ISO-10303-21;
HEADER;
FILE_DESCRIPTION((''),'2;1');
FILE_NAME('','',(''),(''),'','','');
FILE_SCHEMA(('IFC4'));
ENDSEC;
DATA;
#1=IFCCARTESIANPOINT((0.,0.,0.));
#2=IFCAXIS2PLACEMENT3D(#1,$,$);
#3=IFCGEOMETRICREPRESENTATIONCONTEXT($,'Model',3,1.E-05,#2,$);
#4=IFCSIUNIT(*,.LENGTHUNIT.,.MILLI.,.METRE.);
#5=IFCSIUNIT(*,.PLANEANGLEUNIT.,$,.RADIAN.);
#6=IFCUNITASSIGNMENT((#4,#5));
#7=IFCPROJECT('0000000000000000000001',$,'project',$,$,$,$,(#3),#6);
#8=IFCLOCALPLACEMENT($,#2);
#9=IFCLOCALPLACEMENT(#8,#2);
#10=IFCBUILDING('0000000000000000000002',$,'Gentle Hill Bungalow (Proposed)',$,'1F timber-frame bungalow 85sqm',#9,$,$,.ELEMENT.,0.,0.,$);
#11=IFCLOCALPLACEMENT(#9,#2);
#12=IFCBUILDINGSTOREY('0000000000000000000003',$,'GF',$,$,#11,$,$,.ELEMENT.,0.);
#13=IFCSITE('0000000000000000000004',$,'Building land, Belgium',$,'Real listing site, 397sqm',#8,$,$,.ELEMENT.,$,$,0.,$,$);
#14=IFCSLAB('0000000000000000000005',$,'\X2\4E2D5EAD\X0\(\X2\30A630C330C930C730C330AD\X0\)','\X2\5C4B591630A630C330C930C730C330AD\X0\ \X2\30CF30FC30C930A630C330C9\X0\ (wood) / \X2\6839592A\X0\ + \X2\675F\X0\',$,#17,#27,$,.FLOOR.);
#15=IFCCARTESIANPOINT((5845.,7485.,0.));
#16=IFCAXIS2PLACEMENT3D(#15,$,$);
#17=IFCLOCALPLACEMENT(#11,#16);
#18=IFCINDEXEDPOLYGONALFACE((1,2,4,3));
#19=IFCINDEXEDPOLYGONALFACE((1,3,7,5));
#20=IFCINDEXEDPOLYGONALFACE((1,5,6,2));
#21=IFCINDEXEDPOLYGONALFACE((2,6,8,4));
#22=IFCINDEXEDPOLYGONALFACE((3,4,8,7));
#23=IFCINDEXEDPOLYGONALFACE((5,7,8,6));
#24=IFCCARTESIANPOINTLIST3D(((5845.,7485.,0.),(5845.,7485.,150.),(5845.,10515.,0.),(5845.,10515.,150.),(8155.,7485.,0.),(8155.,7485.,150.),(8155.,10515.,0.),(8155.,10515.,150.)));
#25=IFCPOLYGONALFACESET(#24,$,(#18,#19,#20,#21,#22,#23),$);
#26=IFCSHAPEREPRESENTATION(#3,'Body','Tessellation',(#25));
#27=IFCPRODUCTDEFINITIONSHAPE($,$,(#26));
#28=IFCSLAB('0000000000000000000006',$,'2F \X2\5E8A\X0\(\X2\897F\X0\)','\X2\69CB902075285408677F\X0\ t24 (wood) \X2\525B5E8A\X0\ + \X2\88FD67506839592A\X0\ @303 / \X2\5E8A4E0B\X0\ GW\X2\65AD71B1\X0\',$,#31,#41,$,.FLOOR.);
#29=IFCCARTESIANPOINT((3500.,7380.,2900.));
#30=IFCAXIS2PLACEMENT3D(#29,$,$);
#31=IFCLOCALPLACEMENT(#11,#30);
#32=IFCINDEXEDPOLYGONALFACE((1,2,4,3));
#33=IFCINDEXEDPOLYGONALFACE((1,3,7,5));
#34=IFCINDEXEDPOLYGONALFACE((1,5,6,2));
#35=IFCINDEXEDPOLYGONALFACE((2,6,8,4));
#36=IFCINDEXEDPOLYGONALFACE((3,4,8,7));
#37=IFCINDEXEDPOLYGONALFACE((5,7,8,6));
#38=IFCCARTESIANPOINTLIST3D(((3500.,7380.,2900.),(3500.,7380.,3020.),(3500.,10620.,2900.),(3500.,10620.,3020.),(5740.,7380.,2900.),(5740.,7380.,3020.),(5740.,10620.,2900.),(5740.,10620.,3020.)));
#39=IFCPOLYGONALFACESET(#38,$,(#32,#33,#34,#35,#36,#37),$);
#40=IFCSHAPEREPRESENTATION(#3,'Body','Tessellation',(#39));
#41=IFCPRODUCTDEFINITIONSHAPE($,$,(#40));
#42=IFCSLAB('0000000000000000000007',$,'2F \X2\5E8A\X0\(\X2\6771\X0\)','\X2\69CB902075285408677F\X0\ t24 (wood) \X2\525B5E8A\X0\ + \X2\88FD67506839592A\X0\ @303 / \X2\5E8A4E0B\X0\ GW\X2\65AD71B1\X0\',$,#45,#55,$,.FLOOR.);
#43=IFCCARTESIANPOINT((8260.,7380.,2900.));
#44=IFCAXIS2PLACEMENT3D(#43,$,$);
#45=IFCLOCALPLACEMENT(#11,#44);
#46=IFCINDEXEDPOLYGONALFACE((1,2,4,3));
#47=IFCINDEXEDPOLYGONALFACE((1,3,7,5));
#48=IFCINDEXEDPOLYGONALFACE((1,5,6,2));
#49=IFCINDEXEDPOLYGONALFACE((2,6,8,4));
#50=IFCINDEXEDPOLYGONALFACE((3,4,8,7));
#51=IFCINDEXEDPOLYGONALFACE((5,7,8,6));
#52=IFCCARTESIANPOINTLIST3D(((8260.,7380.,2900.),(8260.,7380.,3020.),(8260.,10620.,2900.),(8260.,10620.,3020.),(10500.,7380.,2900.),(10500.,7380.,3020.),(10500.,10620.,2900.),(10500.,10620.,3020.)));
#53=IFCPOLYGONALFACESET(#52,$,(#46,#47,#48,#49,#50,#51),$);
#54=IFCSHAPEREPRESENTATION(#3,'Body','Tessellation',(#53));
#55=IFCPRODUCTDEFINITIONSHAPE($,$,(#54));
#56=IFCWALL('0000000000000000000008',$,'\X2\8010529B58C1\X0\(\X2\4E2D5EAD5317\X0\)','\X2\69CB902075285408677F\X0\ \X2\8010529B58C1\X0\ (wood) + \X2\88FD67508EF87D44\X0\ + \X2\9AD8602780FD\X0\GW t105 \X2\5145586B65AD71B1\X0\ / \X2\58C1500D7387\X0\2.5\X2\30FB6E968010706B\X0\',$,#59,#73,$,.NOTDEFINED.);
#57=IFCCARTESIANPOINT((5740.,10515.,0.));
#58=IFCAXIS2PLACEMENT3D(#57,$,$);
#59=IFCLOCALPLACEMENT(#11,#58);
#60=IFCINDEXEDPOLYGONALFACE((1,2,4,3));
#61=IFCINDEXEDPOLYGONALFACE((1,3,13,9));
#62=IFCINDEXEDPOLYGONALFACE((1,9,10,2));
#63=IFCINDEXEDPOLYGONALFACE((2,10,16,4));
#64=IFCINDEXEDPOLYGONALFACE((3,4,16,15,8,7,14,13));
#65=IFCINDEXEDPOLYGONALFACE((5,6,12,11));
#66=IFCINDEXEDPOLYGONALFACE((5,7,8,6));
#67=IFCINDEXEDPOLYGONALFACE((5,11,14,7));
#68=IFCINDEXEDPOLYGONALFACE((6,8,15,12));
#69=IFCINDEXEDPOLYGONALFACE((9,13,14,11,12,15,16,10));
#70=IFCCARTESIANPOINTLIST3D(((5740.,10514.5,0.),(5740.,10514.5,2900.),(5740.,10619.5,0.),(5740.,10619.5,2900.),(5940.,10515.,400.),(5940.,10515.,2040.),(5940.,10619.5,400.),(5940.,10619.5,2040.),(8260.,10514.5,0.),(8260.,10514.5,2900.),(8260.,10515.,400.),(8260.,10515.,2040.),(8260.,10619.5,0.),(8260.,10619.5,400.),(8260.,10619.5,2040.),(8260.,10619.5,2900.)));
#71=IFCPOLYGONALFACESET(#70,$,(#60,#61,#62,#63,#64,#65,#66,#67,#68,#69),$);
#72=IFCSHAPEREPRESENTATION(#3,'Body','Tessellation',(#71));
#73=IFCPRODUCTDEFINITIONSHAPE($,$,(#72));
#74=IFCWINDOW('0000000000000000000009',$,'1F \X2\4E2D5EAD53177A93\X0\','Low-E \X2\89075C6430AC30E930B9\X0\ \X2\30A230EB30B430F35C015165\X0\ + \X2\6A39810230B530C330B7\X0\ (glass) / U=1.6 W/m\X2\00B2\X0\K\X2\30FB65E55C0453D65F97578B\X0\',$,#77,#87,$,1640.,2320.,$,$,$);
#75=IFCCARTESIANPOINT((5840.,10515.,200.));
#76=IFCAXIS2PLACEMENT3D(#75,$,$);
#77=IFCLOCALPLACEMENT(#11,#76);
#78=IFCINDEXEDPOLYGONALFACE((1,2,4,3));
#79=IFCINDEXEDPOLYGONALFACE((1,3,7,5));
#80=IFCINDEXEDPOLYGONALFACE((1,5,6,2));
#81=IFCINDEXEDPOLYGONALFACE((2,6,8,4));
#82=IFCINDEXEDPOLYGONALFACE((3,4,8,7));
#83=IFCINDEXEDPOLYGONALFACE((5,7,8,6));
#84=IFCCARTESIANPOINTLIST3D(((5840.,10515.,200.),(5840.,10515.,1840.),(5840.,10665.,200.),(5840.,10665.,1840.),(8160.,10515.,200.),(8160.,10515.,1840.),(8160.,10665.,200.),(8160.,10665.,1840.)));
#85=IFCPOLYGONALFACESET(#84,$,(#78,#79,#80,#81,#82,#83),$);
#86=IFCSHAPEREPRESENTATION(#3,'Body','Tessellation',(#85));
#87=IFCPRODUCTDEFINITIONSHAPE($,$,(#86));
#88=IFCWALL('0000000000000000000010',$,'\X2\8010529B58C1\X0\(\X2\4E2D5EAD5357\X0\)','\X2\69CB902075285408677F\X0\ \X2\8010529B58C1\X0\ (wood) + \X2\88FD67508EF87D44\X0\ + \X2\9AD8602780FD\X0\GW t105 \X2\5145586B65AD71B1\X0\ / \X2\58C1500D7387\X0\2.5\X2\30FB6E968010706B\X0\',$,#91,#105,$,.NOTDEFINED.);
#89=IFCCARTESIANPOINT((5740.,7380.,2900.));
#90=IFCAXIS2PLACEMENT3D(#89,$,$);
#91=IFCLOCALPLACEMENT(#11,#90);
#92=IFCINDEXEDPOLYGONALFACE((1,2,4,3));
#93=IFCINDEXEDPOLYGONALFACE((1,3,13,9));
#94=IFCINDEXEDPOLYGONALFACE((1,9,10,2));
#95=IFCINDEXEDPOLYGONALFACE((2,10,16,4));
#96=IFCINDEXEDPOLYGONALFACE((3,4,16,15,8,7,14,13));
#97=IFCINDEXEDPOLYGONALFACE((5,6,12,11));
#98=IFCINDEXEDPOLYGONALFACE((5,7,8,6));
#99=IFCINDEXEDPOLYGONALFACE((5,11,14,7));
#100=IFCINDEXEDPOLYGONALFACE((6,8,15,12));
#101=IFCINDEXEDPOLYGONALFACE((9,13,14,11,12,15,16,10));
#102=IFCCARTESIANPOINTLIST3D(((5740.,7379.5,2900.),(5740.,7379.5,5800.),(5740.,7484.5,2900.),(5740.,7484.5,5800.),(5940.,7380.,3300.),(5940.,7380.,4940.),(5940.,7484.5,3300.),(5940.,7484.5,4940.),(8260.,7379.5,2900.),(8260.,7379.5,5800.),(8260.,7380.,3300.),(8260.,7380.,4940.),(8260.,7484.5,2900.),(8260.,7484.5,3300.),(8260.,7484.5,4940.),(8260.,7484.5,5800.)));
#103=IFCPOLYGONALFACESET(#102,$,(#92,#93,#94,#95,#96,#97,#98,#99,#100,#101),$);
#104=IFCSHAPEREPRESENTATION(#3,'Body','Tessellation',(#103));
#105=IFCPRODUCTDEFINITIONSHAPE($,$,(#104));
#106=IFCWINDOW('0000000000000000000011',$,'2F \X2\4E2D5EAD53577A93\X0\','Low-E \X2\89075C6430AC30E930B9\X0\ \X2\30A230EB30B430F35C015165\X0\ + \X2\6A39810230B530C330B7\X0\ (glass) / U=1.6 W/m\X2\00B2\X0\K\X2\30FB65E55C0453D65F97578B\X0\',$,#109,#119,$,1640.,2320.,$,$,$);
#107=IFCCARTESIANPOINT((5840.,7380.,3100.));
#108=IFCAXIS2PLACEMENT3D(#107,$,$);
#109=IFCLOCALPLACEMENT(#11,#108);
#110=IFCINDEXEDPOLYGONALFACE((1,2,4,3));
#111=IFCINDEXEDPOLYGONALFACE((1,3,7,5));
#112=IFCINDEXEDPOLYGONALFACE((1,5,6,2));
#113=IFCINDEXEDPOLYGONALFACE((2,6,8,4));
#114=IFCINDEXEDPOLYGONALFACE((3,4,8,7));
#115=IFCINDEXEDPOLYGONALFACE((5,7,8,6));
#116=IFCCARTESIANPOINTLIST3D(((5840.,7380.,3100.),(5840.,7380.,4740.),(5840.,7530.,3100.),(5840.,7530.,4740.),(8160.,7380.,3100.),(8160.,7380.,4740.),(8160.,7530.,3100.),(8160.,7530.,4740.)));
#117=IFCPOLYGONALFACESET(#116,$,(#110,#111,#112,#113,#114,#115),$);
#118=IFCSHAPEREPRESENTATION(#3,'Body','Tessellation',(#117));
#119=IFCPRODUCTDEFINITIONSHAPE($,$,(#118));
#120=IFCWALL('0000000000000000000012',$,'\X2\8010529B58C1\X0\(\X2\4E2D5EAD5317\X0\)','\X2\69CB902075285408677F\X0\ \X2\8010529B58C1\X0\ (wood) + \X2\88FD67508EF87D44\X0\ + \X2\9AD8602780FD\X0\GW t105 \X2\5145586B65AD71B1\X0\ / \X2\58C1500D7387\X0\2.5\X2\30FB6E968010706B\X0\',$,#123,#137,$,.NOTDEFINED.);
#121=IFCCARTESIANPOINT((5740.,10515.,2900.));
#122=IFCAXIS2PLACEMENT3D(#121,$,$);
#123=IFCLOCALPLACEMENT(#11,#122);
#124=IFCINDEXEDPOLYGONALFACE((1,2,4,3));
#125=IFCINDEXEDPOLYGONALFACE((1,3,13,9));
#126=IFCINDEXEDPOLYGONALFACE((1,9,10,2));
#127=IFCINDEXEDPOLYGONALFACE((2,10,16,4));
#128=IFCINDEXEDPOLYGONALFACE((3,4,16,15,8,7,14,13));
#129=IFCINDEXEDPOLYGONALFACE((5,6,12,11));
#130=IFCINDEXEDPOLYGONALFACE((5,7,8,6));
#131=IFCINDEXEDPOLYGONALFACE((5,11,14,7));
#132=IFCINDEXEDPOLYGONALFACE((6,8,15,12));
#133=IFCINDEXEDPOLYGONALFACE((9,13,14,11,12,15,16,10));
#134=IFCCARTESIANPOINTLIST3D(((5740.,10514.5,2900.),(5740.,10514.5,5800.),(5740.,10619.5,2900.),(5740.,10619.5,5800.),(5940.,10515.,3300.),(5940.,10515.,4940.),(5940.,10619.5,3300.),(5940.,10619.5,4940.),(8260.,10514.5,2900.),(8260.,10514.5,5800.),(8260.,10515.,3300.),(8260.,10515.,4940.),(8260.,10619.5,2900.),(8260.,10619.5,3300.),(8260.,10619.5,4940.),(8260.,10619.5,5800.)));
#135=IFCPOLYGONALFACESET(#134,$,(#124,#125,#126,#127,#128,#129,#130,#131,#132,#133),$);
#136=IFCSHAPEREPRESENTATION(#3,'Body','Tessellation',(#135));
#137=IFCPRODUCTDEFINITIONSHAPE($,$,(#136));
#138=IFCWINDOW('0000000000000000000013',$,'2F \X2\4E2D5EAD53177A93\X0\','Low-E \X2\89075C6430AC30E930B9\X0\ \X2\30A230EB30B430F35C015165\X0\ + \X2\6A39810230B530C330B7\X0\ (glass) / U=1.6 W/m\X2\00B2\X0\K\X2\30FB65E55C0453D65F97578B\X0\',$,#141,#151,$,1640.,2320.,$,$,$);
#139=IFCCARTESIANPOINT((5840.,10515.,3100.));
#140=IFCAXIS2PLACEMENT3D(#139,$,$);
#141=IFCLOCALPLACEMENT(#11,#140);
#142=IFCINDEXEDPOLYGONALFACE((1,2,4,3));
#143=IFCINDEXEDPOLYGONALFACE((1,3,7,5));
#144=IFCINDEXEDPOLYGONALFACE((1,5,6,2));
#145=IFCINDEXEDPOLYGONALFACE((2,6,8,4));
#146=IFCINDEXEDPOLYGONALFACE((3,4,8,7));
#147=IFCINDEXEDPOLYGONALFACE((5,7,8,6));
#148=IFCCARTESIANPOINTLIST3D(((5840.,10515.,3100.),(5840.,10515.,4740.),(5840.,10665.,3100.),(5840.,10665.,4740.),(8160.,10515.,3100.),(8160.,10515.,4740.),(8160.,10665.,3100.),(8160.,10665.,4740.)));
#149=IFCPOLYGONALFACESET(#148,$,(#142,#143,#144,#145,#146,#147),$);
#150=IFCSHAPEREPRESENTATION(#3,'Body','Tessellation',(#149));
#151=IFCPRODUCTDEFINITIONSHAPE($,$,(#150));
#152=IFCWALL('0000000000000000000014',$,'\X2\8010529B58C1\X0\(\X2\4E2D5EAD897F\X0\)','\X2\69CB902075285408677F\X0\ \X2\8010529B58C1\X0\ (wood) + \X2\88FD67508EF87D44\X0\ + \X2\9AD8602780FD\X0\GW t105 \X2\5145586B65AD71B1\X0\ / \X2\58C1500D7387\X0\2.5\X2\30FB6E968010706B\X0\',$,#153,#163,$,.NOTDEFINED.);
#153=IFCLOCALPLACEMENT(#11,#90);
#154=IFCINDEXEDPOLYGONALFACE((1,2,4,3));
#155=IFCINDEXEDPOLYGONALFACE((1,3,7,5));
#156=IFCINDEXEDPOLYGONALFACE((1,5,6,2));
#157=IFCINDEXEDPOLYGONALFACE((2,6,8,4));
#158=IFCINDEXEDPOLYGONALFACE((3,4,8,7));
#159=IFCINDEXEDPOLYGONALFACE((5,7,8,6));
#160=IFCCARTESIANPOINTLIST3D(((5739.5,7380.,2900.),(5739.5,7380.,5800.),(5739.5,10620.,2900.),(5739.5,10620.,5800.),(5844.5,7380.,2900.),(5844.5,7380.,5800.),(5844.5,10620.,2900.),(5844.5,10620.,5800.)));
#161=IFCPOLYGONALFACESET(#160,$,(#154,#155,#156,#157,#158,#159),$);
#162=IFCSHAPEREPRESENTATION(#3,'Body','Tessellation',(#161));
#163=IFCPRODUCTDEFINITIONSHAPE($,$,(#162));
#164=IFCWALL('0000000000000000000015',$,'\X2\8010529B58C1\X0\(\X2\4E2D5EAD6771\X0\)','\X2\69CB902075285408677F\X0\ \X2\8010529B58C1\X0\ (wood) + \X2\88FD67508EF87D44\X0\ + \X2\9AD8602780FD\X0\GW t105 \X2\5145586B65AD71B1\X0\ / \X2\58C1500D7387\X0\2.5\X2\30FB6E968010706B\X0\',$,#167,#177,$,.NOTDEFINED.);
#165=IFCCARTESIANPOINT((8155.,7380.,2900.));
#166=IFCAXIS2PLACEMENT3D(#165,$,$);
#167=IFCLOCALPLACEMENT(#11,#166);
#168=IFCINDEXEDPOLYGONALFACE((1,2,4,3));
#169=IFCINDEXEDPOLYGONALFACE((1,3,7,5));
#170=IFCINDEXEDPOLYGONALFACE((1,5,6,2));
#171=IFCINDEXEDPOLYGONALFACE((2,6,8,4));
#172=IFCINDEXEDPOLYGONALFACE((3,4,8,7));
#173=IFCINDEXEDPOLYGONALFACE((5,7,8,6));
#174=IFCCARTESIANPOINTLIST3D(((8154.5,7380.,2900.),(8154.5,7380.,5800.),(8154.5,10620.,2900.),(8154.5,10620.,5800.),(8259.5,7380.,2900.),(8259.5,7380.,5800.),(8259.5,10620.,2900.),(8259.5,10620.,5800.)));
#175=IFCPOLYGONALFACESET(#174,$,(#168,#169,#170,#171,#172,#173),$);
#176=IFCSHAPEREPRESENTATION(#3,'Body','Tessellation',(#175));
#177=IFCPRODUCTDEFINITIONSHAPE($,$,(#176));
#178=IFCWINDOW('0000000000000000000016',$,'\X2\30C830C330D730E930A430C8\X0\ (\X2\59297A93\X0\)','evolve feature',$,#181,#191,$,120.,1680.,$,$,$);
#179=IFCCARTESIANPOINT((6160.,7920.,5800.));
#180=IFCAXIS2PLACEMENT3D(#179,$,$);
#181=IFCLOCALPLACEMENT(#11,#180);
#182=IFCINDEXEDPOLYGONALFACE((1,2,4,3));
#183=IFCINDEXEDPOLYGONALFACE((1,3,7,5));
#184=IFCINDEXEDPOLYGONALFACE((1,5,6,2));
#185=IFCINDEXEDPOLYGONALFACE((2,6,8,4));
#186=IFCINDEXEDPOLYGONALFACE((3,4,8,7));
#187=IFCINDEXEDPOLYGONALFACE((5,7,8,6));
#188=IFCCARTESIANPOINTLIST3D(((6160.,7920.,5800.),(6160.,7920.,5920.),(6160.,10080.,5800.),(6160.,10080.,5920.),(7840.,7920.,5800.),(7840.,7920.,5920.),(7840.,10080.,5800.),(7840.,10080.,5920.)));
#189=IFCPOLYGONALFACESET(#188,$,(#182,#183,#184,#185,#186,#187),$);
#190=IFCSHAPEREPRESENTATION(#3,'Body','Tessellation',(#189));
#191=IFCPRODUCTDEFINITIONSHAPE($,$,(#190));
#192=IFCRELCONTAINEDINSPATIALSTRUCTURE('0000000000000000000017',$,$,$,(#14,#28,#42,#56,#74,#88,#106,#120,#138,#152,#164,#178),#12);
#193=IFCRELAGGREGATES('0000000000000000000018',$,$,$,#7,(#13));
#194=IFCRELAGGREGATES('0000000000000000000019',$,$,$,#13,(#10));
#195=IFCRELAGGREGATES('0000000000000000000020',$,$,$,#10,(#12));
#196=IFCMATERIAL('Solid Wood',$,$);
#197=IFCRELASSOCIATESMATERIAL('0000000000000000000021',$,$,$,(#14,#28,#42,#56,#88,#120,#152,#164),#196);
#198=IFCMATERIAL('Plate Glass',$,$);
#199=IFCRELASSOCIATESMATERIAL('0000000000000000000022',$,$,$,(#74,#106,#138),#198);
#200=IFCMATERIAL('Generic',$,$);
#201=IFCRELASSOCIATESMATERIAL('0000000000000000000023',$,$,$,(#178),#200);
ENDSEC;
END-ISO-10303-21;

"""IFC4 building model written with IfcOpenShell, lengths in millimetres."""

from ifc_helpers import new_model, si_unit, frame, frame_2d, origin, place, context, project, spatial, rectangle, extrude, material, element, fill, save


model = new_model("IFC4")

# Units and contexts
model_context = context("Model", 3, precision=1e-05, world=origin())
ifc_project = project(units=[si_unit("LENGTHUNIT", "METRE", prefix="MILLI"), si_unit("PLANEANGLEUNIT", "RADIAN")], contexts=[model_context])

# Site, building, storey
site_placement = place(None, origin())
site = spatial("IfcSite", under=ifc_project, at=site_placement, Name="Building land, Belgium", ObjectType="Real listing site, 397sqm", CompositionType="ELEMENT", RefElevation=0.0)
building_placement = place(site_placement, origin())
building = spatial("IfcBuilding", under=site, at=building_placement, Name="Gentle Hill Bungalow (Proposed)", ObjectType="1F timber-frame bungalow 85sqm", CompositionType="ELEMENT", ElevationOfRefHeight=0.0, ElevationOfTerrain=0.0)
storey_placement = place(building_placement, origin())
storey = spatial("IfcBuildingStorey", under=building, at=storey_placement, Name="GF", CompositionType="ELEMENT", Elevation=0.0)

# Slabs
ifc_material_1 = material(Name="Solid Wood")
slab_1_placement = place(storey_placement, frame((5845.0, 7485.0, 0.0)))
element("IfcSlab", 1, at=slab_1_placement, inside=storey, material=ifc_material_1, Name="中庭(ウッドデッキ)", Description="屋外ウッドデッキ ハードウッド (wood) / 根太 + 束", PredefinedType="FLOOR", context=model_context, shape_type="SweptSolid", body=[
    extrude(rectangle(XDim=2310.0, YDim=3030.0, at=frame_2d((1155.0, 1515.0))), frame((5845.0, 7485.0, 0.0)), (0.0, 0.0, 1.0), 150.0),
])
slab_2_placement = place(storey_placement, frame((3500.0, 7380.0, 2900.0)))
element("IfcSlab", 2, at=slab_2_placement, inside=storey, material=ifc_material_1, Name="2F 床(西)", Description="構造用合板 t24 (wood) 剛床 + 製材根太 @303 / 床下 GW断熱", PredefinedType="FLOOR", context=model_context, shape_type="SweptSolid", body=[
    extrude(rectangle(XDim=2240.0, YDim=3240.0, at=frame_2d((1120.0, 1620.0))), frame((3500.0, 7380.0, 2900.0)), (0.0, 0.0, 1.0), 120.0),
])
slab_3_placement = place(storey_placement, frame((8260.0, 7380.0, 2900.0)))
element("IfcSlab", 3, at=slab_3_placement, inside=storey, material=ifc_material_1, Name="2F 床(東)", Description="構造用合板 t24 (wood) 剛床 + 製材根太 @303 / 床下 GW断熱", PredefinedType="FLOOR", context=model_context, shape_type="SweptSolid", body=[
    extrude(rectangle(XDim=2240.0, YDim=3240.0, at=frame_2d((1120.0, 1620.0))), frame((8260.0, 7380.0, 2900.0)), (0.0, 0.0, 1.0), 120.0),
])

# Walls, openings, windows
wall_1_placement = place(storey_placement, frame((5740.0, 10515.0, 0.0)))
wall_1 = element("IfcWall", 4, at=wall_1_placement, inside=storey, material=ifc_material_1, Name="耐力壁(中庭北)", Description="構造用合板 耐力壁 (wood) + 製材軸組 + 高性能GW t105 充填断熱 / 壁倍率2.5・準耐火", PredefinedType="NOTDEFINED", context=model_context, shape_type="SweptSolid", body=[
    extrude(rectangle(XDim=2520.0, YDim=105.0, at=frame_2d((1260.0, 52.0))), frame((5740.0, 10515.0, 0.0)), (0.0, 0.0, 1.0), 2900.0),
])
opening_1_placement = place(storey_placement, frame((5840.0, 10515.0, 200.0)))
opening_1 = element("IfcOpeningElement", 5, at=opening_1_placement, cuts=wall_1, PredefinedType="NOTDEFINED", context=model_context, shape_type="SweptSolid", body=[
    extrude(rectangle(XDim=2320.0, YDim=150.0, at=frame_2d((1160.0, 75.0))), frame((5840.0, 10515.0, 200.0)), (0.0, 0.0, 1.0), 1640.0),
])
ifc_material_2 = material(Name="Plate Glass")
window_1_placement = place(storey_placement, frame((5840.0, 10515.0, 200.0)))
window_1 = element("IfcWindow", 6, at=window_1_placement, inside=storey, material=ifc_material_2, Name="1F 中庭北窓", Description="Low-E 複層ガラス アルゴン封入 + 樹脂サッシ (glass) / U=1.6 W/m²K・日射取得型", OverallHeight=1640.0, OverallWidth=2320.0, context=model_context, shape_type="SweptSolid", body=[
    extrude(rectangle(XDim=2320.0, YDim=150.0, at=frame_2d((1160.0, 75.0))), frame((5840.0, 10515.0, 200.0)), (0.0, 0.0, 1.0), 1640.0),
])
fill(opening_1, window_1)
wall_2_placement = place(storey_placement, frame((5740.0, 7380.0, 2900.0)))
wall_2 = element("IfcWall", 7, at=wall_2_placement, inside=storey, material=ifc_material_1, Name="耐力壁(中庭南)", Description="構造用合板 耐力壁 (wood) + 製材軸組 + 高性能GW t105 充填断熱 / 壁倍率2.5・準耐火", PredefinedType="NOTDEFINED", context=model_context, shape_type="SweptSolid", body=[
    extrude(rectangle(XDim=2520.0, YDim=105.0, at=frame_2d((1260.0, 52.0))), frame((5740.0, 7380.0, 2900.0)), (0.0, 0.0, 1.0), 2900.0),
])
opening_2_placement = place(storey_placement, frame((5840.0, 7380.0, 3100.0)))
opening_2 = element("IfcOpeningElement", 8, at=opening_2_placement, cuts=wall_2, PredefinedType="NOTDEFINED", context=model_context, shape_type="SweptSolid", body=[
    extrude(rectangle(XDim=2320.0, YDim=150.0, at=frame_2d((1160.0, 75.0))), frame((5840.0, 7380.0, 3100.0)), (0.0, 0.0, 1.0), 1640.0),
])
window_2_placement = place(storey_placement, frame((5840.0, 7380.0, 3100.0)))
window_2 = element("IfcWindow", 9, at=window_2_placement, inside=storey, material=ifc_material_2, Name="2F 中庭南窓", Description="Low-E 複層ガラス アルゴン封入 + 樹脂サッシ (glass) / U=1.6 W/m²K・日射取得型", OverallHeight=1640.0, OverallWidth=2320.0, context=model_context, shape_type="SweptSolid", body=[
    extrude(rectangle(XDim=2320.0, YDim=150.0, at=frame_2d((1160.0, 75.0))), frame((5840.0, 7380.0, 3100.0)), (0.0, 0.0, 1.0), 1640.0),
])
fill(opening_2, window_2)
wall_3_placement = place(storey_placement, frame((5740.0, 10515.0, 2900.0)))
wall_3 = element("IfcWall", 10, at=wall_3_placement, inside=storey, material=ifc_material_1, Name="耐力壁(中庭北)", Description="構造用合板 耐力壁 (wood) + 製材軸組 + 高性能GW t105 充填断熱 / 壁倍率2.5・準耐火", PredefinedType="NOTDEFINED", context=model_context, shape_type="SweptSolid", body=[
    extrude(rectangle(XDim=2520.0, YDim=105.0, at=frame_2d((1260.0, 52.0))), frame((5740.0, 10515.0, 2900.0)), (0.0, 0.0, 1.0), 2900.0),
])
opening_3_placement = place(storey_placement, frame((5840.0, 10515.0, 3100.0)))
opening_3 = element("IfcOpeningElement", 11, at=opening_3_placement, cuts=wall_3, PredefinedType="NOTDEFINED", context=model_context, shape_type="SweptSolid", body=[
    extrude(rectangle(XDim=2320.0, YDim=150.0, at=frame_2d((1160.0, 75.0))), frame((5840.0, 10515.0, 3100.0)), (0.0, 0.0, 1.0), 1640.0),
])
window_3_placement = place(storey_placement, frame((5840.0, 10515.0, 3100.0)))
window_3 = element("IfcWindow", 12, at=window_3_placement, inside=storey, material=ifc_material_2, Name="2F 中庭北窓", Description="Low-E 複層ガラス アルゴン封入 + 樹脂サッシ (glass) / U=1.6 W/m²K・日射取得型", OverallHeight=1640.0, OverallWidth=2320.0, context=model_context, shape_type="SweptSolid", body=[
    extrude(rectangle(XDim=2320.0, YDim=150.0, at=frame_2d((1160.0, 75.0))), frame((5840.0, 10515.0, 3100.0)), (0.0, 0.0, 1.0), 1640.0),
])
fill(opening_3, window_3)

# Walls
wall_4_placement = place(storey_placement, frame((5740.0, 7380.0, 2900.0)))
element("IfcWall", 13, at=wall_4_placement, inside=storey, material=ifc_material_1, Name="耐力壁(中庭西)", Description="構造用合板 耐力壁 (wood) + 製材軸組 + 高性能GW t105 充填断熱 / 壁倍率2.5・準耐火", PredefinedType="NOTDEFINED", context=model_context, shape_type="SweptSolid", body=[
    extrude(rectangle(XDim=105.0, YDim=3240.0, at=frame_2d((52.0, 1620.0))), frame((5740.0, 7380.0, 2900.0)), (0.0, 0.0, 1.0), 2900.0),
])
wall_5_placement = place(storey_placement, frame((8155.0, 7380.0, 2900.0)))
element("IfcWall", 14, at=wall_5_placement, inside=storey, material=ifc_material_1, Name="耐力壁(中庭東)", Description="構造用合板 耐力壁 (wood) + 製材軸組 + 高性能GW t105 充填断熱 / 壁倍率2.5・準耐火", PredefinedType="NOTDEFINED", context=model_context, shape_type="SweptSolid", body=[
    extrude(rectangle(XDim=105.0, YDim=3240.0, at=frame_2d((52.0, 1620.0))), frame((8155.0, 7380.0, 2900.0)), (0.0, 0.0, 1.0), 2900.0),
])

# Window
ifc_material_3 = material(Name="Generic")
window_4_placement = place(storey_placement, frame((6160.0, 7920.0, 5800.0)))
element("IfcWindow", 15, at=window_4_placement, inside=storey, material=ifc_material_3, Name="トップライト (天窓)", Description="evolve feature", OverallHeight=120.0, OverallWidth=1680.0, context=model_context, shape_type="SweptSolid", body=[
    extrude(rectangle(XDim=1680.0, YDim=2160.0, at=frame_2d((840.0, 1080.0))), frame((6160.0, 7920.0, 5800.0)), (0.0, 0.0, 1.0), 120.0),
])

save(model, "model.ifc")
